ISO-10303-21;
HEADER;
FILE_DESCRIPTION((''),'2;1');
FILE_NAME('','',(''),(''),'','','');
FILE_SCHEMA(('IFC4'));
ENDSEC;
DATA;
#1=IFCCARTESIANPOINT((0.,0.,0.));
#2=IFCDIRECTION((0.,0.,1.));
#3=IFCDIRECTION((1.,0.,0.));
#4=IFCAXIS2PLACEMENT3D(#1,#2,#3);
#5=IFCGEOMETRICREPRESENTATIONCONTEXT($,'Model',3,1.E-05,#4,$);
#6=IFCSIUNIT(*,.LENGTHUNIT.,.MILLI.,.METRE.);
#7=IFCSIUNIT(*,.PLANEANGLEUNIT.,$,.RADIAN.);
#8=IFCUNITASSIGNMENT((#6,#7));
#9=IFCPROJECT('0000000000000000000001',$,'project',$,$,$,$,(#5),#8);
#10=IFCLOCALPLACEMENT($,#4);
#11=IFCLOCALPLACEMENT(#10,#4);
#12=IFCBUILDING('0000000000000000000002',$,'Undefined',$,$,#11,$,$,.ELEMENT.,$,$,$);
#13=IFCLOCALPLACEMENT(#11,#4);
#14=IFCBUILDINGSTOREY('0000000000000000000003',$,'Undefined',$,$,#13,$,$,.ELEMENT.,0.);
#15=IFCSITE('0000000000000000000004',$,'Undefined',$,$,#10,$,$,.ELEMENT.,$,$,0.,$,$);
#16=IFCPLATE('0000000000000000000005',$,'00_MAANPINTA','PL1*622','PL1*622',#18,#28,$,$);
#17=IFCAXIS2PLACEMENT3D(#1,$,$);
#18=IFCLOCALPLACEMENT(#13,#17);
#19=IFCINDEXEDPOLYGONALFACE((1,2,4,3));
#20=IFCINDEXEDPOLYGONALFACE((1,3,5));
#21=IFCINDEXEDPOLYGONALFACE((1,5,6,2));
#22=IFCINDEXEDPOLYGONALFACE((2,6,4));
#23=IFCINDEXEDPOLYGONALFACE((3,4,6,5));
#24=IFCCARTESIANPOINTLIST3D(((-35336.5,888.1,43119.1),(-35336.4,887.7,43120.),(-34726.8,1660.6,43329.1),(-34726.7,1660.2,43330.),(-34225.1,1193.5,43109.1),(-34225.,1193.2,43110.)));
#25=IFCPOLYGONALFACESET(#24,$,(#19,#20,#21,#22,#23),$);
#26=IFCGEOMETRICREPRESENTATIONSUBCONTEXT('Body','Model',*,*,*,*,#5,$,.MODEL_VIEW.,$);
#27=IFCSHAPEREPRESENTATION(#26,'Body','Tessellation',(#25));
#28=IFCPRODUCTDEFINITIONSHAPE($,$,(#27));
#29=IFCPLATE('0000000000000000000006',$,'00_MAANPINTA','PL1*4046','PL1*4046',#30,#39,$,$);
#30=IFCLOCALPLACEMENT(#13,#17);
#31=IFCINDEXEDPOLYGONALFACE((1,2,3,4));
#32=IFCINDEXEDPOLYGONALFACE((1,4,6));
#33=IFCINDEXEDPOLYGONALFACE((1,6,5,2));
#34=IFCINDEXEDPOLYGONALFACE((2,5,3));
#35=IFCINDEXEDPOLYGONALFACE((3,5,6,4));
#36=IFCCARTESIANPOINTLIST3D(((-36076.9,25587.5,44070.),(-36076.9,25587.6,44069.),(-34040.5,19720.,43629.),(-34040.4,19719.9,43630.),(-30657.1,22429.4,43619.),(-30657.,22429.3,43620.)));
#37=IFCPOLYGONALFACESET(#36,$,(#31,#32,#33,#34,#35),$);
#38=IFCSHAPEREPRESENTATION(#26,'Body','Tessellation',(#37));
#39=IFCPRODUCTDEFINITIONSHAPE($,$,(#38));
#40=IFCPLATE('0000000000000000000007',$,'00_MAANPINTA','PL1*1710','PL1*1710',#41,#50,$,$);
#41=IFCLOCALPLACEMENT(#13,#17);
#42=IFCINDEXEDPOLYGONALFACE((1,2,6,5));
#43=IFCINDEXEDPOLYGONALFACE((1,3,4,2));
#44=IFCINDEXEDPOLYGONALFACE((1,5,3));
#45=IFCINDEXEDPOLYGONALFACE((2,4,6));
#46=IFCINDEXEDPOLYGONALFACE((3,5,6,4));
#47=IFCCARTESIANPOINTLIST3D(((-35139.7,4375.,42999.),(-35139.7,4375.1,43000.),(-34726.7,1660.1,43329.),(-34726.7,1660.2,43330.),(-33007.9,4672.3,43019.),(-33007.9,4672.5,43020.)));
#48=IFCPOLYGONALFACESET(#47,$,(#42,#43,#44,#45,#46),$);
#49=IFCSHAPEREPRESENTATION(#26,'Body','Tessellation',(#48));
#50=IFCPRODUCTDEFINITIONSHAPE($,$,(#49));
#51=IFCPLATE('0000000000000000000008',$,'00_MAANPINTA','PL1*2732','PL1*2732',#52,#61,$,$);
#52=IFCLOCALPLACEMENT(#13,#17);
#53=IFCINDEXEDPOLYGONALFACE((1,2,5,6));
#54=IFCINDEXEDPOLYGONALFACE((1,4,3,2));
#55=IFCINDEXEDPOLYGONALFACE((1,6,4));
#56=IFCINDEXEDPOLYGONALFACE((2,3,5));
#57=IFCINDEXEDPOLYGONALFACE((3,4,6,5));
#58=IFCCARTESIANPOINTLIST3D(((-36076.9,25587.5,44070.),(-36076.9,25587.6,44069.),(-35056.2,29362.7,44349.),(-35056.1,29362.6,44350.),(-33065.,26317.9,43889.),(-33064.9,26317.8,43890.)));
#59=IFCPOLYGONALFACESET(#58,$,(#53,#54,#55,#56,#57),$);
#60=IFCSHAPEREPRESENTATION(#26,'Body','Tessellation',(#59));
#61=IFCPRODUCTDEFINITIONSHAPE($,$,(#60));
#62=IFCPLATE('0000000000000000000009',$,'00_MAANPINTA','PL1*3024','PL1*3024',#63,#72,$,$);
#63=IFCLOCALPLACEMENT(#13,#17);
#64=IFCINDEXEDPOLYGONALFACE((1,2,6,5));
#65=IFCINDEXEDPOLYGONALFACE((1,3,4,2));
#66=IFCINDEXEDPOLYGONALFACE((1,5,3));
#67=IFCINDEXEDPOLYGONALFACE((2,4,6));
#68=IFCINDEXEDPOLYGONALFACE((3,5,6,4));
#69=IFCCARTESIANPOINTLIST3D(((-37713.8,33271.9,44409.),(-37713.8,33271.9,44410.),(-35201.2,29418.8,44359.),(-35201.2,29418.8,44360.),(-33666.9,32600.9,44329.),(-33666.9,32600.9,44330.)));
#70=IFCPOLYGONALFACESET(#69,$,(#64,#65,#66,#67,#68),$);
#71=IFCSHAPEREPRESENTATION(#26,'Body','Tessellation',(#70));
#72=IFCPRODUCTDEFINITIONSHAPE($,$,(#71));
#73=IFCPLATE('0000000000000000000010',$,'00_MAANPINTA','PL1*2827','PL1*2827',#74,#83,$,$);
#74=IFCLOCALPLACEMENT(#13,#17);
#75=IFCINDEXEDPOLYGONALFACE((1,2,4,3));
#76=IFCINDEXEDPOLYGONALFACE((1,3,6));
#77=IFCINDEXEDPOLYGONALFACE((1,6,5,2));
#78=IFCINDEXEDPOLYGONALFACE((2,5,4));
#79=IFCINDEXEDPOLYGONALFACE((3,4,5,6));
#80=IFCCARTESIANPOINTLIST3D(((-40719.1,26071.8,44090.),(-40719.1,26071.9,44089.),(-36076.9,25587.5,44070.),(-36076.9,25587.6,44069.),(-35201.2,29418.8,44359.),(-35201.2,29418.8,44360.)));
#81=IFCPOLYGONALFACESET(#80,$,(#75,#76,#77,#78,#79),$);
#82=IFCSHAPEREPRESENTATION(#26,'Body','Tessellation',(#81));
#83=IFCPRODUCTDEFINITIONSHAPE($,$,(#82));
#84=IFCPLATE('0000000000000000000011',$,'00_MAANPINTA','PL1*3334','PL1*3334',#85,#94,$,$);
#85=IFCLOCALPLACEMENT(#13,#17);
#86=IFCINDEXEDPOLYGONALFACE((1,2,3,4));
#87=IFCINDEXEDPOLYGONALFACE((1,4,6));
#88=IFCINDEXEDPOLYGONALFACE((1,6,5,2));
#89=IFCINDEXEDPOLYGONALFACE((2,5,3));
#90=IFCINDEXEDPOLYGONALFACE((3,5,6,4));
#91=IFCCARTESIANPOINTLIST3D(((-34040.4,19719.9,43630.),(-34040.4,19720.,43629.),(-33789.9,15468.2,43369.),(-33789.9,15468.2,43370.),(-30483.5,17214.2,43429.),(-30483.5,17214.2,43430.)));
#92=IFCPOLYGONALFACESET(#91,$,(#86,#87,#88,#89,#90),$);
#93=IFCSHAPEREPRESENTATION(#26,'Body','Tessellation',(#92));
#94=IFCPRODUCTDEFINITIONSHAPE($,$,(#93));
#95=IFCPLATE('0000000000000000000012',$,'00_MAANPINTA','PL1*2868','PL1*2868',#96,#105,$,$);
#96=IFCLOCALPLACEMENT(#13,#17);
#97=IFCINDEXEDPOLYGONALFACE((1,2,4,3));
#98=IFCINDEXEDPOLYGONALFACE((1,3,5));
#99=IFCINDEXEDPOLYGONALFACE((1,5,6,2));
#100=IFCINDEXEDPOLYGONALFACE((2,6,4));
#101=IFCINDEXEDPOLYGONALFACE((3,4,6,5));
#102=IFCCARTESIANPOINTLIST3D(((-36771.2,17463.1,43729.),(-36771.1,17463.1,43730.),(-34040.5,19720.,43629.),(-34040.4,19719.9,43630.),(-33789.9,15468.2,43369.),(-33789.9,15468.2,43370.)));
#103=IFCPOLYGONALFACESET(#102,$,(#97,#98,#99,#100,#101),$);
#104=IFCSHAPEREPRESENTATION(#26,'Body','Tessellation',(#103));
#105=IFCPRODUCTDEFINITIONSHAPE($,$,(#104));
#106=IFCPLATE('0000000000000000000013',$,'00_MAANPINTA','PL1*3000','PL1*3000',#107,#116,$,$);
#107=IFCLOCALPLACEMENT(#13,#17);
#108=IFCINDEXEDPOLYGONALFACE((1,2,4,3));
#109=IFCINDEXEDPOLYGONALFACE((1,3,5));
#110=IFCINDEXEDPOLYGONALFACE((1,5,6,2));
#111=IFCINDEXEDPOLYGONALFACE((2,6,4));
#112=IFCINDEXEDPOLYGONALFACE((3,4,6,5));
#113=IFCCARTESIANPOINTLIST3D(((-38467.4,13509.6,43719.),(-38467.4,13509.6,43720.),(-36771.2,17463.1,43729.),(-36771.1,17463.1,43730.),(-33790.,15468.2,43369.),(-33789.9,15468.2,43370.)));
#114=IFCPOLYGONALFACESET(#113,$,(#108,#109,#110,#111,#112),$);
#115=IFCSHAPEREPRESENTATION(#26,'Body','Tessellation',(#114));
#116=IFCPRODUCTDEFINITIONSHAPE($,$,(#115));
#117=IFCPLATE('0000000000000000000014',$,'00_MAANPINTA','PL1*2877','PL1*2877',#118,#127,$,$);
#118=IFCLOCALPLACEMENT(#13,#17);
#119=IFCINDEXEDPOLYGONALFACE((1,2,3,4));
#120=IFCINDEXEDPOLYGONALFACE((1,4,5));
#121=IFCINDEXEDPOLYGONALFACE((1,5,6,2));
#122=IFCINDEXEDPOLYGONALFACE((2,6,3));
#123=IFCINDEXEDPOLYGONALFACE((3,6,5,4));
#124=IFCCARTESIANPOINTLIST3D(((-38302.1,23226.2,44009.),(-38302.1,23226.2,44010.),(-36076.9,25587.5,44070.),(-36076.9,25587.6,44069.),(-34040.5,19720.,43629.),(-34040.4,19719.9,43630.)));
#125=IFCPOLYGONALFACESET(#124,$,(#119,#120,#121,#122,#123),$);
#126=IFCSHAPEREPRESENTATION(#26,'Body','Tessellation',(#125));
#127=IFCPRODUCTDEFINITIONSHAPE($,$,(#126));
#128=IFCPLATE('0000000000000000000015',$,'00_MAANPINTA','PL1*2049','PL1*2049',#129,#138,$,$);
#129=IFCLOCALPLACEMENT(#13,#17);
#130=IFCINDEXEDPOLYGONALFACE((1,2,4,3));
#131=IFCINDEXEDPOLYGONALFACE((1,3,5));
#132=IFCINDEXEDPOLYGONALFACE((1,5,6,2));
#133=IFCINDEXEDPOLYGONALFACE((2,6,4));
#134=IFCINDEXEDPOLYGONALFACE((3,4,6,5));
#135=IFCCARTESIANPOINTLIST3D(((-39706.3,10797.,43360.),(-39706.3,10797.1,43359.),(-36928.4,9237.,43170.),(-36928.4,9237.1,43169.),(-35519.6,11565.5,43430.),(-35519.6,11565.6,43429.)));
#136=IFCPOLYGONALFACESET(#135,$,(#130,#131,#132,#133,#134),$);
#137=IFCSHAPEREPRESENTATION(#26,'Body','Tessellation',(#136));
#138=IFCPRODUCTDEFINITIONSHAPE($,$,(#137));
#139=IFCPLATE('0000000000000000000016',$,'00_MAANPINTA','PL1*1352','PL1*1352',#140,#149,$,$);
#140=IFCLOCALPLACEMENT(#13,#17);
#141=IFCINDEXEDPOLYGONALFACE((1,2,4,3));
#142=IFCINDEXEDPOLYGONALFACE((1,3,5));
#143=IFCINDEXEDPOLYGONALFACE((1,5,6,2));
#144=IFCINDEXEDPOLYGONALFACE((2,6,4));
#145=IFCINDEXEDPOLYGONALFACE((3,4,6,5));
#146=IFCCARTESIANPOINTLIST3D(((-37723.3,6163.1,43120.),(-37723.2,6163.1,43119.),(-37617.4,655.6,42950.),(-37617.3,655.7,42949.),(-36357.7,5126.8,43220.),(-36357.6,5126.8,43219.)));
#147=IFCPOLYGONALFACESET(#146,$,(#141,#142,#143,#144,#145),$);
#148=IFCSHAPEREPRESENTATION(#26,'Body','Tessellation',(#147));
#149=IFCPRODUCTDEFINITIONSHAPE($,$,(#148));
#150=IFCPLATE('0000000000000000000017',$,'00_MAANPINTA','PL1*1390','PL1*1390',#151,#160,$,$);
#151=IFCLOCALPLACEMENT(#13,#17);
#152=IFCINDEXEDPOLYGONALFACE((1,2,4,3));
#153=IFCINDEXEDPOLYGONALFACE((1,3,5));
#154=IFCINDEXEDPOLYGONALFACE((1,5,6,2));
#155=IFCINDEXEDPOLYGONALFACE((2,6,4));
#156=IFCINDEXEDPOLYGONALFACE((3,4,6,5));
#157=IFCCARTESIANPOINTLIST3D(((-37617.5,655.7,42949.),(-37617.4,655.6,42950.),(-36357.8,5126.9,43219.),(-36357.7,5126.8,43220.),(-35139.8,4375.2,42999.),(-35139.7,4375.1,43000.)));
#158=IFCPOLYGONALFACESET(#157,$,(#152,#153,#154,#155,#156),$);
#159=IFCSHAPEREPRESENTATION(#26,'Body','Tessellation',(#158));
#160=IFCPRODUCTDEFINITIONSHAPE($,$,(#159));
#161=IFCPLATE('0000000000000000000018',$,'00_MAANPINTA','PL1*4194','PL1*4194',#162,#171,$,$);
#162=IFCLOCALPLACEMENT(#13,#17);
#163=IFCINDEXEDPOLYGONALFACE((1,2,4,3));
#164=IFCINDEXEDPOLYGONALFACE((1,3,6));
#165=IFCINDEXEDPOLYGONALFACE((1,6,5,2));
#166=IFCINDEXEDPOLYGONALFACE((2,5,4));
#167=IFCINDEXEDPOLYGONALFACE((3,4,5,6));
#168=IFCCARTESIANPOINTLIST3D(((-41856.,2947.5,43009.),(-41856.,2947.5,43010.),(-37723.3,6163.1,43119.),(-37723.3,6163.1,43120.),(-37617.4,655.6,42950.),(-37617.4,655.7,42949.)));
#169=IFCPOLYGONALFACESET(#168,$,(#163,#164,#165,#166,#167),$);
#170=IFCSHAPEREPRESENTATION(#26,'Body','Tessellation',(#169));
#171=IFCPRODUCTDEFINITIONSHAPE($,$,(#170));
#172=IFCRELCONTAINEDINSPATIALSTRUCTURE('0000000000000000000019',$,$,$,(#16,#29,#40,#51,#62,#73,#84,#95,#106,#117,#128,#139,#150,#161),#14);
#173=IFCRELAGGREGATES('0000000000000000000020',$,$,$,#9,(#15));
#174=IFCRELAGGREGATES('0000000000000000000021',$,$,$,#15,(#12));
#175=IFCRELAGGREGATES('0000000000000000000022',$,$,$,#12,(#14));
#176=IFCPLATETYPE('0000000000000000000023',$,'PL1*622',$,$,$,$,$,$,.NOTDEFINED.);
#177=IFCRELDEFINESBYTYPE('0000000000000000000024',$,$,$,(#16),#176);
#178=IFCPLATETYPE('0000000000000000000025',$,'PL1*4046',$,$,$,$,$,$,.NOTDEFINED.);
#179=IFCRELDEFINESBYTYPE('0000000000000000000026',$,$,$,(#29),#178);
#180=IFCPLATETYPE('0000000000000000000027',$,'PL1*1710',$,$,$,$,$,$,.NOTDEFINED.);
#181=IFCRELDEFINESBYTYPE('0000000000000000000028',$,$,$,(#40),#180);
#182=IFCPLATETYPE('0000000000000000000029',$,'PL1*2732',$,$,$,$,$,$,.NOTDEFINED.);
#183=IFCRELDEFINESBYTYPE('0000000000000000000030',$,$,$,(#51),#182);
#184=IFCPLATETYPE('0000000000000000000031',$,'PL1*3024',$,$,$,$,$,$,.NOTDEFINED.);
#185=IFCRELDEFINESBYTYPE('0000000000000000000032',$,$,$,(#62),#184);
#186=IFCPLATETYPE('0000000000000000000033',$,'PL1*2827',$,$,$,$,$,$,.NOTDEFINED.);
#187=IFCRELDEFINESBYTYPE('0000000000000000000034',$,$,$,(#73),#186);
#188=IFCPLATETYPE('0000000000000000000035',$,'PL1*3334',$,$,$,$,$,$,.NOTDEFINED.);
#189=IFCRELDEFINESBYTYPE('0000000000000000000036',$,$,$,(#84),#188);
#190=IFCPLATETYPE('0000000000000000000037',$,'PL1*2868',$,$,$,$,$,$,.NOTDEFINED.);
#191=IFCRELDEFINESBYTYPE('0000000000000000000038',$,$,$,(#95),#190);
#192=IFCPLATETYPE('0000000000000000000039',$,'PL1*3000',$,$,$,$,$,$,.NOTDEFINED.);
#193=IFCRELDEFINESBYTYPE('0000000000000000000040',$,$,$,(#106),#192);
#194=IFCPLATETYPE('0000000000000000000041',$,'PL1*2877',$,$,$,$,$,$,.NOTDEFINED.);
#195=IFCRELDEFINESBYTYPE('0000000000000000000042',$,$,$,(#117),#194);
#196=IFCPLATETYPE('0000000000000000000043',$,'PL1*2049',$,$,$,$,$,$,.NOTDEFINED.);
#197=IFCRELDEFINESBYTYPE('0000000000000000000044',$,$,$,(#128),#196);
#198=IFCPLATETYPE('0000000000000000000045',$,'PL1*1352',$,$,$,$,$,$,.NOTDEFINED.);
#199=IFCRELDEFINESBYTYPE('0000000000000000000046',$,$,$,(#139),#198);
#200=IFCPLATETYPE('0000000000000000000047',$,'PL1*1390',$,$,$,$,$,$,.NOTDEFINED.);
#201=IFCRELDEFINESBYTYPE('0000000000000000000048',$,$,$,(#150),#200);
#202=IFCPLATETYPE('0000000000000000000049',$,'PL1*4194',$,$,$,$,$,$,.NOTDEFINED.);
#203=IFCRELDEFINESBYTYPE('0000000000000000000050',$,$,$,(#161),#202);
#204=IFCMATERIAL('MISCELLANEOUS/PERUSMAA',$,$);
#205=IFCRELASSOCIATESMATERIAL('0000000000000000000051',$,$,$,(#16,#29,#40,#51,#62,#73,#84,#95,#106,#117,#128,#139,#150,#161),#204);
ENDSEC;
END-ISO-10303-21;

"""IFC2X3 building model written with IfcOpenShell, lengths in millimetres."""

from ifc_helpers import new_model, si_unit, frame, origin_with_axes, place, context, subcontext, project, spatial, polyline, outline, extrude, material, type_object, element, save


model = new_model("IFC2X3")

# Units and contexts
model_context = context("Model", 3, precision=1e-05, world=origin_with_axes())
body_context = subcontext(model_context, "Body", "Model", "MODEL_VIEW")
ifc_project = project(units=[si_unit("LENGTHUNIT", "METRE", prefix="MILLI"), si_unit("PLANEANGLEUNIT", "RADIAN")], contexts=[model_context])

# Site, building, storey
site_placement = place(None, origin_with_axes())
site = spatial("IfcSite", under=ifc_project, at=site_placement, Name="Undefined", CompositionType="ELEMENT", RefElevation=0.0)
building_placement = place(site_placement, origin_with_axes())
building = spatial("IfcBuilding", under=site, at=building_placement, Name="Undefined", CompositionType="ELEMENT")
storey_placement = place(building_placement, origin_with_axes())
storey = spatial("IfcBuildingStorey", under=building, at=storey_placement, Name="Undefined", CompositionType="ELEMENT", Elevation=0.0)

# Plates
ifc_material = material(Name="MISCELLANEOUS/PERUSMAA")
plate_type_1 = type_object("IfcPlateType", Name="PL1*622", PredefinedType="NOTDEFINED")
plate_1_placement = place(storey_placement, frame((-34726.8, 1660.4, 43329.5), z_axis=(-0.100201, 0.333879, -0.937275), x_axis=(0.696913, -0.648778, -0.305615)))
element("IfcPlate", 1, at=plate_1_placement, inside=storey, type_object=plate_type_1, material=ifc_material, Name="00_MAANPINTA", Description="PL1*622", ObjectType="PL1*622", context=body_context, shape_type="SweptSolid", body=[
    extrude(outline(polyline([(0.0, 0.0), (719.9, 0.0), (140.4, 996.4), (0.0, 0.0)])), frame((0.0, 0.0, -0.5), z_axis=(0.0, 0.0, 1.0), x_axis=(1.0, 0.0, 0.0)), (0.0, 0.0, 1.0), 1.0),
])
plate_type_2 = type_object("IfcPlateType", Name="PL1*4046", PredefinedType="NOTDEFINED")
plate_2_placement = place(storey_placement, frame((-36076.9, 25587.6, 44069.5), z_axis=(-0.049161, 0.05771, -0.997122), x_axis=(0.861796, -0.502183, -0.071554)))
element("IfcPlate", 2, at=plate_2_placement, inside=storey, type_object=plate_type_2, material=ifc_material, Name="00_MAANPINTA", Description="PL1*4046", ObjectType="PL1*4046", context=body_context, shape_type="SweptSolid", body=[
    extrude(outline(polyline([(0.0, 0.0), (6289.0, 0.0), (4733.1, 4045.7), (0.0, 0.0)])), frame((0.0, 0.0, -0.5), z_axis=(0.0, 0.0, 1.0), x_axis=(1.0, 0.0, 0.0)), (0.0, 0.0, 1.0), 1.0),
])
plate_type_3 = type_object("IfcPlateType", Name="PL1*1710", PredefinedType="NOTDEFINED")
plate_3_placement = place(storey_placement, frame((-34726.7, 1660.2, 43329.5), z_axis=(0.025606, -0.116787, -0.992827), x_axis=(-0.14932, 0.981564, -0.119313)))
element("IfcPlate", 3, at=plate_3_placement, inside=storey, type_object=plate_type_3, material=ifc_material, Name="00_MAANPINTA", Description="PL1*1710", ObjectType="PL1*1710", context=body_context, shape_type="SweptSolid", body=[
    extrude(outline(polyline([(0.0, 0.0), (2765.8, 0.0), (2737.0, 2152.3), (0.0, 0.0)])), frame((0.0, 0.0, -0.5), z_axis=(0.0, 0.0, 1.0), x_axis=(1.0, 0.0, 0.0)), (0.0, 0.0, 1.0), 1.0),
])
plate_type_4 = type_object("IfcPlateType", Name="PL1*2732", PredefinedType="NOTDEFINED")
plate_4_placement = place(storey_placement, frame((-35056.2, 29362.7, 44349.5), z_axis=(-0.082529, 0.095889, -0.991965), x_axis=(0.54299, -0.830317, -0.125439)))
element("IfcPlate", 4, at=plate_4_placement, inside=storey, type_object=plate_type_4, material=ifc_material, Name="00_MAANPINTA", Description="PL1*2732", ObjectType="PL1*2732", context=body_context, shape_type="SweptSolid", body=[
    extrude(outline(polyline([(0.0, 0.0), (3667.1, 0.0), (2615.4, 2920.8), (0.0, 0.0)])), frame((0.0, 0.0, -0.5), z_axis=(0.0, 0.0, 1.0), x_axis=(1.0, 0.0, 0.0)), (0.0, 0.0, 1.0), 1.0),
])
plate_type_5 = type_object("IfcPlateType", Name="PL1*3024", PredefinedType="NOTDEFINED")
plate_5_placement = place(storey_placement, frame((-35201.2, 29418.8, 44359.5), z_axis=(-0.019748, 0.000096, -0.999805), x_axis=(-0.54618, 0.837597, 0.010869)))
element("IfcPlate", 5, at=plate_5_placement, inside=storey, type_object=plate_type_5, material=ifc_material, Name="00_MAANPINTA", Description="PL1*3024", ObjectType="PL1*3024", context=body_context, shape_type="SweptSolid", body=[
    extrude(outline(polyline([(0.0, 0.0), (4600.2, 0.0), (1827.0, 3023.8), (0.0, 0.0)])), frame((0.0, 0.0, -0.5), z_axis=(0.0, 0.0, 1.0), x_axis=(1.0, 0.0, 0.0)), (0.0, 0.0, 1.0), 1.0),
])
plate_type_6 = type_object("IfcPlateType", Name="PL1*2827", PredefinedType="NOTDEFINED")
plate_6_placement = place(storey_placement, frame((-36076.9, 25587.6, 44069.5), z_axis=(0.003495, 0.074683, -0.997201), x_axis=(-0.994593, 0.10376, 0.004285)))
element("IfcPlate", 6, at=plate_6_placement, inside=storey, type_object=plate_type_6, material=ifc_material, Name="00_MAANPINTA", Description="PL1*2827", ObjectType="PL1*2827", context=body_context, shape_type="SweptSolid", body=[
    extrude(outline(polyline([(0.0, 0.0), (4667.5, 0.0), (-472.1, 3912.3), (0.0, 0.0)])), frame((0.0, 0.0, -0.5), z_axis=(0.0, 0.0, 1.0), x_axis=(1.0, 0.0, 0.0)), (0.0, 0.0, 1.0), 1.0),
])
plate_type_7 = type_object("IfcPlateType", Name="PL1*3334", PredefinedType="NOTDEFINED")
plate_7_placement = place(storey_placement, frame((-34040.4, 19719.9, 43629.5), z_axis=(-0.013692, 0.060228, -0.998091), x_axis=(0.816648, -0.575306, -0.045919)))
element("IfcPlate", 7, at=plate_7_placement, inside=storey, type_object=plate_type_7, material=ifc_material, Name="00_MAANPINTA", Description="PL1*3334", ObjectType="PL1*3334", context=body_context, shape_type="SweptSolid", body=[
    extrude(outline(polyline([(0.0, 0.0), (4355.5, 0.0), (2662.6, 3334.4), (0.0, 0.0)])), frame((0.0, 0.0, -0.5), z_axis=(0.0, 0.0, 1.0), x_axis=(1.0, 0.0, 0.0)), (0.0, 0.0, 1.0), 1.0),
])
plate_type_8 = type_object("IfcPlateType", Name="PL1*2868", PredefinedType="NOTDEFINED")
plate_8_placement = place(storey_placement, frame((-33789.9, 15468.2, 43369.5), z_axis=(-0.082698, 0.055972, -0.995002), x_axis=(-0.826937, 0.553357, 0.099858)))
element("IfcPlate", 8, at=plate_8_placement, inside=storey, type_object=plate_type_8, material=ifc_material, Name="00_MAANPINTA", Description="PL1*2868", ObjectType="PL1*2868", context=body_context, shape_type="SweptSolid", body=[
    extrude(outline(polyline([(0.0, 0.0), (3605.1, 0.0), (2585.9, 3394.2), (0.0, 0.0)])), frame((0.0, 0.0, -0.5), z_axis=(0.0, 0.0, 1.0), x_axis=(1.0, 0.0, 0.0)), (0.0, 0.0, 1.0), 1.0),
])
plate_type_9 = type_object("IfcPlateType", Name="PL1*3000", PredefinedType="NOTDEFINED")
plate_9_placement = place(storey_placement, frame((-36771.1, 17463.1, 43729.5), z_axis=(-0.09203, 0.042003, -0.99487), x_axis=(0.826937, -0.553357, -0.099858)))
element("IfcPlate", 9, at=plate_9_placement, inside=storey, type_object=plate_type_9, material=ifc_material, Name="00_MAANPINTA", Description="PL1*3000", ObjectType="PL1*3000", context=body_context, shape_type="SweptSolid", body=[
    extrude(outline(polyline([(0.0, 0.0), (3605.1, 0.0), (786.0, 4229.6), (0.0, 0.0)])), frame((0.0, 0.0, -0.5), z_axis=(0.0, 0.0, 1.0), x_axis=(1.0, 0.0, 0.0)), (0.0, 0.0, 1.0), 1.0),
])
plate_type_10 = type_object("IfcPlateType", Name="PL1*2877", PredefinedType="NOTDEFINED")
plate_10_placement = place(storey_placement, frame((-34040.4, 19719.9, 43629.5), z_axis=(-0.03835, 0.061481, -0.997371), x_axis=(-0.770403, 0.633845, 0.068695)))
element("IfcPlate", 10, at=plate_10_placement, inside=storey, type_object=plate_type_10, material=ifc_material, Name="00_MAANPINTA", Description="PL1*2877", ObjectType="PL1*2877", context=body_context, shape_type="SweptSolid", body=[
    extrude(outline(polyline([(0.0, 0.0), (5531.7, 0.0), (5318.3, 3238.2), (0.0, 0.0)])), frame((0.0, 0.0, -0.5), z_axis=(0.0, 0.0, 1.0), x_axis=(1.0, 0.0, 0.0)), (0.0, 0.0, 1.0), 1.0),
])
plate_type_11 = type_object("IfcPlateType", Name="PL1*2049", PredefinedType="NOTDEFINED")
plate_11_placement = place(storey_placement, frame((-36928.4, 9237.1, 43169.5), z_axis=(-0.004222, 0.113493, -0.99353), x_axis=(-0.870386, 0.488759, 0.05953)))
element("IfcPlate", 11, at=plate_11_placement, inside=storey, type_object=plate_type_11, material=ifc_material, Name="00_MAANPINTA", Description="PL1*2049", ObjectType="PL1*2049", context=body_context, shape_type="SweptSolid", body=[
    extrude(outline(polyline([(0.0, 0.0), (3191.7, 0.0), (-72.7, 2732.9), (0.0, 0.0)])), frame((0.0, 0.0, -0.5), z_axis=(0.0, 0.0, 1.0), x_axis=(1.0, 0.0, 0.0)), (0.0, 0.0, 1.0), 1.0),
])
plate_type_12 = type_object("IfcPlateType", Name="PL1*1352", PredefinedType="NOTDEFINED")
plate_12_placement = place(storey_placement, frame((-37723.3, 6163.1, 43119.5), z_axis=(0.097561, 0.03258, -0.994696), x_axis=(0.795254, -0.603473, 0.058233)))
element("IfcPlate", 12, at=plate_12_placement, inside=storey, type_object=plate_type_12, material=ifc_material, Name="00_MAANPINTA", Description="PL1*1352", ObjectType="PL1*1352", context=body_context, shape_type="SweptSolid", body=[
    extrude(outline(polyline([(0.0, 0.0), (1717.2, 0.0), (3398.0, 4338.9), (0.0, 0.0)])), frame((0.0, 0.0, -0.5), z_axis=(0.0, 0.0, 1.0), x_axis=(1.0, 0.0, 0.0)), (0.0, 0.0, 1.0), 1.0),
])
plate_type_13 = type_object("IfcPlateType", Name="PL1*1390", PredefinedType="NOTDEFINED")
plate_13_placement = place(storey_placement, frame((-36357.7, 5126.8, 43219.5), z_axis=(-0.12069, 0.093681, -0.98826), x_axis=(0.841091, -0.519118, -0.151927)))
element("IfcPlate", 13, at=plate_13_placement, inside=storey, type_object=plate_type_13, material=ifc_material, Name="00_MAANPINTA", Description="PL1*1390", ObjectType="PL1*1390", context=body_context, shape_type="SweptSolid", body=[
    extrude(outline(polyline([(0.0, 0.0), (1448.1, 0.0), (1302.6, 4467.0), (0.0, 0.0)])), frame((0.0, 0.0, -0.5), z_axis=(0.0, 0.0, 1.0), x_axis=(1.0, 0.0, 0.0)), (0.0, 0.0, 1.0), 1.0),
])
plate_type_14 = type_object("IfcPlateType", Name="PL1*4194", PredefinedType="NOTDEFINED")
plate_14_placement = place(storey_placement, frame((-37617.4, 655.7, 42949.5), z_axis=(0.00256, 0.030902, -0.999519), x_axis=(-0.879579, 0.47559, 0.012451)))
element("IfcPlate", 14, at=plate_14_placement, inside=storey, type_object=plate_type_14, material=ifc_material, Name="00_MAANPINTA", Description="PL1*4194", ObjectType="PL1*4194", context=body_context, shape_type="SweptSolid", body=[
    extrude(outline(polyline([(0.0, 0.0), (4818.9, 0.0), (2714.6, 4796.2), (0.0, 0.0)])), frame((0.0, 0.0, -0.5), z_axis=(0.0, 0.0, 1.0), x_axis=(1.0, 0.0, 0.0)), (0.0, 0.0, 1.0), 1.0),
])

save(model, "model.ifc")
